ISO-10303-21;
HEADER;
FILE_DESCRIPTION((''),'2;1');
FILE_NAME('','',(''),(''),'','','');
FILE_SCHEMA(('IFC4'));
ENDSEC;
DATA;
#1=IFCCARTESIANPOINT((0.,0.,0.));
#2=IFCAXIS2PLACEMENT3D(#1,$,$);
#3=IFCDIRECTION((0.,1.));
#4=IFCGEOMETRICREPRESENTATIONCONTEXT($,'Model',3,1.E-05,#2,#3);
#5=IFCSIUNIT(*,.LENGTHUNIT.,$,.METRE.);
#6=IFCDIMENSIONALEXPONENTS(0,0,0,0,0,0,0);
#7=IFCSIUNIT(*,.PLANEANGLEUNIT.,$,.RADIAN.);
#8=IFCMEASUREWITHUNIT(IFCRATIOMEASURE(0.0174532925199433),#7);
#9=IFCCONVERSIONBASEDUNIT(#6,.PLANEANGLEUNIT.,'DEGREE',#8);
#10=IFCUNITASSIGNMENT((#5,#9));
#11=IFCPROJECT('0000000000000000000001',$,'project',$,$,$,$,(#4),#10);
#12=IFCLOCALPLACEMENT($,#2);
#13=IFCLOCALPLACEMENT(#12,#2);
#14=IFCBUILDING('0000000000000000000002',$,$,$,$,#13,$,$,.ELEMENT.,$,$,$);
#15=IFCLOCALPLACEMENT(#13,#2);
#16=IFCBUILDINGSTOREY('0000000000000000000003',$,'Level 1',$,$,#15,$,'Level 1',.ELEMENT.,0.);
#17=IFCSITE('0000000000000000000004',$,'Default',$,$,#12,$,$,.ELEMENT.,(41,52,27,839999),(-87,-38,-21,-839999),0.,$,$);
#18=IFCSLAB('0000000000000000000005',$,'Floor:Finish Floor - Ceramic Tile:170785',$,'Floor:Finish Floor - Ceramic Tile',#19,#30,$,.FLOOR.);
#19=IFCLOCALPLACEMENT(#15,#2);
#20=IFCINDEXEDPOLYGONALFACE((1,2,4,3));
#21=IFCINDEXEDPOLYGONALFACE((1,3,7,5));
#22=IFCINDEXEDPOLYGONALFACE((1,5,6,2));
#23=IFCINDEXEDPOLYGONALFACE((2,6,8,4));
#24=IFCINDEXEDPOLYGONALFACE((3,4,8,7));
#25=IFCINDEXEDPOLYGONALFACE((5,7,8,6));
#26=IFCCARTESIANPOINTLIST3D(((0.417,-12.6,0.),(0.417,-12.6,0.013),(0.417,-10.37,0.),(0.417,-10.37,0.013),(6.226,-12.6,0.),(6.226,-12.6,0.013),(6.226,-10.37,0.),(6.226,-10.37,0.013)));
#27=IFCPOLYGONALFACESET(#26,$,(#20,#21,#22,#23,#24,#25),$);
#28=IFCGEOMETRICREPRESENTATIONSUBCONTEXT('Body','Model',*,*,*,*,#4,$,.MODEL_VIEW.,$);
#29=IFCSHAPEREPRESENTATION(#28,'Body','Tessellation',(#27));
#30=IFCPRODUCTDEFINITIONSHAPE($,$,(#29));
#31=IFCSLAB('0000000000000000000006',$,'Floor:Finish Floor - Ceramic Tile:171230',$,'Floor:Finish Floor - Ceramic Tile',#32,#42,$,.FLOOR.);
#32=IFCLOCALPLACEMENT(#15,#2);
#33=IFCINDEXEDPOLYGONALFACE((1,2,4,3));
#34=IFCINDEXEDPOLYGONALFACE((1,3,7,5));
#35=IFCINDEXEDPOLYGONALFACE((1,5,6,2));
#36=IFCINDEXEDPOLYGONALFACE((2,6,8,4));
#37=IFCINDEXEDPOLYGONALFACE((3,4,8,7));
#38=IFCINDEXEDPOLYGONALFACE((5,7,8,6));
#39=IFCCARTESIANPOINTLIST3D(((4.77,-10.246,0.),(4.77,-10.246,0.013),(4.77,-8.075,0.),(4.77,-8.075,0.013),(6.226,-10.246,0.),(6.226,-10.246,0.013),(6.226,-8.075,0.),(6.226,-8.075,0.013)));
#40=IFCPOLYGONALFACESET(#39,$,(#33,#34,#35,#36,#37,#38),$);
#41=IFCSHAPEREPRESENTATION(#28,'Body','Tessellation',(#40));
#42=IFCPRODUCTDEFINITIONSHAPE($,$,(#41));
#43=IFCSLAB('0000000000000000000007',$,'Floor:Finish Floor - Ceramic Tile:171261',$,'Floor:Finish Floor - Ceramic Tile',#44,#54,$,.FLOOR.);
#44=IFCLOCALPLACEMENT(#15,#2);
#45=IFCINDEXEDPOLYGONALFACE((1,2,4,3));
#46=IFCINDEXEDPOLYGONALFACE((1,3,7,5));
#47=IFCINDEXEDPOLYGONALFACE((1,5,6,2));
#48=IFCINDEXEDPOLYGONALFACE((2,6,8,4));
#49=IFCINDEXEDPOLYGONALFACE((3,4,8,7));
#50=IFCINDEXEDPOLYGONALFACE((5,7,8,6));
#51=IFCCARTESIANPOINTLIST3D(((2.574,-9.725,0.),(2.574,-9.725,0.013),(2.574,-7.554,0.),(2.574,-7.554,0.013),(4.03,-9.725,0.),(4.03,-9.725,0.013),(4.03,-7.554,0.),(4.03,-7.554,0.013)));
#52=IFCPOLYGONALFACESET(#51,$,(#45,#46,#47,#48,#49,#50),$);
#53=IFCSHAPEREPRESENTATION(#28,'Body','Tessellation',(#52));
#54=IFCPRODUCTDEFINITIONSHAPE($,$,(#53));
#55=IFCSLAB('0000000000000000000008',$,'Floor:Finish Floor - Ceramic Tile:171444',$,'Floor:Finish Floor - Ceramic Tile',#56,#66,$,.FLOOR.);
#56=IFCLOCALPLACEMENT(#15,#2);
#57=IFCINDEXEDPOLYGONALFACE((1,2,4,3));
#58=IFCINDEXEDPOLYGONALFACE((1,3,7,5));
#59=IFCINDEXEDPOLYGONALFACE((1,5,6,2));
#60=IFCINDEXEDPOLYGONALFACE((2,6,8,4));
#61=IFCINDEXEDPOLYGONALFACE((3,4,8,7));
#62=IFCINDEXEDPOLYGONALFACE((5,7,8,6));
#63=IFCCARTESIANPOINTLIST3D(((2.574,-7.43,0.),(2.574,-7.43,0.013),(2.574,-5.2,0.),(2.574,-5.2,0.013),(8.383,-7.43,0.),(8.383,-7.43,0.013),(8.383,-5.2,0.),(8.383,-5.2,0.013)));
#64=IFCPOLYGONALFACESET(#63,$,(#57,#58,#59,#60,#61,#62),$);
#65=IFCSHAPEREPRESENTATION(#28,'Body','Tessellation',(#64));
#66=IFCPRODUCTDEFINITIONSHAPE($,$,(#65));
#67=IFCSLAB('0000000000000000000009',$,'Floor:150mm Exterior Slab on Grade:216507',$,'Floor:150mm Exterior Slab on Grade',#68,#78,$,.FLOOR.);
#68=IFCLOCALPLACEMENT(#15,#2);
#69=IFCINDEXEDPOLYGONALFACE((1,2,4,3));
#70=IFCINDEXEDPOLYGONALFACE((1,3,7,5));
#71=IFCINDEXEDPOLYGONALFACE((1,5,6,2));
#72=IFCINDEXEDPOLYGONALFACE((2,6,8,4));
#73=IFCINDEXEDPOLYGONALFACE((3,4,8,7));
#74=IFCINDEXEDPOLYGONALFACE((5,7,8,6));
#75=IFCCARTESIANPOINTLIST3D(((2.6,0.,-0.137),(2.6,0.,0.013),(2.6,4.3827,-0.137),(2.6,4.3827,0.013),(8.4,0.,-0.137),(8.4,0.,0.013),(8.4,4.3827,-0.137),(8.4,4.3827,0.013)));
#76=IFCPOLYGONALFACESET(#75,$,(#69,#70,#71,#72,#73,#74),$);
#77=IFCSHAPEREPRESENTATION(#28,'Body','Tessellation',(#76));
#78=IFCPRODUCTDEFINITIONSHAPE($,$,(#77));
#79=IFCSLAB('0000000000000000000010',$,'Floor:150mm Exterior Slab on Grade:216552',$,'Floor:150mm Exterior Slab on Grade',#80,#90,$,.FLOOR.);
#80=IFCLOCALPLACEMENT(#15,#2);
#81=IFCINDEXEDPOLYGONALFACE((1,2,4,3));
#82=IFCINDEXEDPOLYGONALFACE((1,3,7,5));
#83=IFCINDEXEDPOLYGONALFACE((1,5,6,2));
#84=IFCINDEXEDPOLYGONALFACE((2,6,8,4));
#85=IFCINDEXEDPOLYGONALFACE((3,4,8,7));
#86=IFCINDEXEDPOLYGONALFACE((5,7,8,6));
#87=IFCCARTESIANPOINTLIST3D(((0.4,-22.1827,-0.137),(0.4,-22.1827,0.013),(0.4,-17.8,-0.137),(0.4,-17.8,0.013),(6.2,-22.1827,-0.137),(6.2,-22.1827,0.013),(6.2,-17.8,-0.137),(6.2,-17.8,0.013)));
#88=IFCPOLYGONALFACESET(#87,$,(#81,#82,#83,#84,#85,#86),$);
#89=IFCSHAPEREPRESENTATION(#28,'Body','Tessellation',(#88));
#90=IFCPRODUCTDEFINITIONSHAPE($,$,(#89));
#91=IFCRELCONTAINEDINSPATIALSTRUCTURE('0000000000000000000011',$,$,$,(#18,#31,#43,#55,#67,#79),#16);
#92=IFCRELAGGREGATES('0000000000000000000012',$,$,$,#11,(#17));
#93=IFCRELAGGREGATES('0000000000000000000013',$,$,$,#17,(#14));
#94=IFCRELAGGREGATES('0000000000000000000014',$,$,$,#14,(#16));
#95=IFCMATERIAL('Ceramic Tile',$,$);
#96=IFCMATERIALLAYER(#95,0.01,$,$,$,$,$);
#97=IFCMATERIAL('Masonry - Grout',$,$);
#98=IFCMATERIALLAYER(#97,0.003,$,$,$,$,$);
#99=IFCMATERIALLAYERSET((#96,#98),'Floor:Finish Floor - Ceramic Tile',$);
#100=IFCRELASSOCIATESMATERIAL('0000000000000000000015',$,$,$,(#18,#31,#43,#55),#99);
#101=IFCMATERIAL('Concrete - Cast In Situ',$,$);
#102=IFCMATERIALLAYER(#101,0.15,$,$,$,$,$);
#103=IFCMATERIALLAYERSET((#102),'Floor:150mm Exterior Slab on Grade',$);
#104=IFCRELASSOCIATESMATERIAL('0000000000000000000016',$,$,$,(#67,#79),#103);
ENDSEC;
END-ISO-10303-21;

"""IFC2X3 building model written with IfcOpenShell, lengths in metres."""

from ifc_helpers import new_model, entity, si_unit, converted_unit, direction, frame, frame_2d, origin, place, context, subcontext, project, spatial, rectangle, extrude, material, layer, layer_set, layer_usage, element, save


model = new_model("IFC2X3")

# Units and contexts
model_context = context("Model", 3, precision=1e-05, world=origin(), true_north=direction((0.0, 1.0)))
body_context = subcontext(model_context, "Body", "Model", "MODEL_VIEW")
ifc_project = project(units=[si_unit("LENGTHUNIT", "METRE"), converted_unit("PLANEANGLEUNIT", "DEGREE", entity("IfcRatioMeasure", 0.0174532925199433), si_unit("PLANEANGLEUNIT", "RADIAN"), dimensions=[0, 0, 0, 0, 0, 0, 0])], contexts=[model_context])

# Site, building, storey
site_placement = place(None, origin())
site = spatial("IfcSite", under=ifc_project, at=site_placement, Name="Default", CompositionType="ELEMENT", RefLatitude=(41, 52, 27, 839999), RefLongitude=(-87, -38, -21, -839999), RefElevation=0.0)
building_placement = place(site_placement, origin())
building = spatial("IfcBuilding", under=site, at=building_placement, CompositionType="ELEMENT")
storey_placement = place(building_placement, origin())
storey = spatial("IfcBuildingStorey", under=building, at=storey_placement, Name="Level 1", LongName="Level 1", CompositionType="ELEMENT", Elevation=0.0)

# Slabs
ifc_material_1 = material(Name="Ceramic Tile")
ifc_layer_1 = layer(ifc_material_1, 0.01)
ifc_material_2 = material(Name="Masonry - Grout")
ifc_layer_2 = layer(ifc_material_2, 0.003)
ifc_layer_set_1 = layer_set([ifc_layer_1, ifc_layer_2], Name="Floor:Finish Floor - Ceramic Tile")
ifc_layer_usage_1 = layer_usage(ifc_layer_set_1, "AXIS3", "POSITIVE", 0.0)
slab_1_placement = place(storey_placement, origin())
element("IfcSlab", 1, at=slab_1_placement, inside=storey, material=ifc_layer_usage_1, Name="Floor:Finish Floor - Ceramic Tile:170785", ObjectType="Floor:Finish Floor - Ceramic Tile", PredefinedType="FLOOR", context=body_context, shape_type="SweptSolid", body=[
    extrude(rectangle(XDim=2.23, YDim=5.809, at=frame_2d((0.0, 0.0), x_axis=(1.0, 0.0))), frame((3.3215, -11.485, 0.013), z_axis=(0.0, 0.0, -1.0), x_axis=(0.0, 1.0, 0.0)), (0.0, 0.0, 1.0), 0.013),
])
ifc_layer_usage_2 = layer_usage(ifc_layer_set_1, "AXIS3", "POSITIVE", 0.0)
slab_2_placement = place(storey_placement, origin())
element("IfcSlab", 2, at=slab_2_placement, inside=storey, material=ifc_layer_usage_2, Name="Floor:Finish Floor - Ceramic Tile:171230", ObjectType="Floor:Finish Floor - Ceramic Tile", PredefinedType="FLOOR", context=body_context, shape_type="SweptSolid", body=[
    extrude(rectangle(XDim=2.171, YDim=1.456, at=frame_2d((0.0, 0.0), x_axis=(1.0, 0.0))), frame((5.498, -9.1605, 0.013), z_axis=(0.0, 0.0, -1.0), x_axis=(0.0, 1.0, 0.0)), (0.0, 0.0, 1.0), 0.013),
])
ifc_layer_usage_3 = layer_usage(ifc_layer_set_1, "AXIS3", "POSITIVE", 0.0)
slab_3_placement = place(storey_placement, origin())
element("IfcSlab", 3, at=slab_3_placement, inside=storey, material=ifc_layer_usage_3, Name="Floor:Finish Floor - Ceramic Tile:171261", ObjectType="Floor:Finish Floor - Ceramic Tile", PredefinedType="FLOOR", context=body_context, shape_type="SweptSolid", body=[
    extrude(rectangle(XDim=2.171, YDim=1.456, at=frame_2d((0.0, 0.0), x_axis=(1.0, 0.0))), frame((3.302, -8.6395, 0.013), z_axis=(0.0, 0.0, -1.0), x_axis=(0.0, 1.0, 0.0)), (0.0, 0.0, 1.0), 0.013),
])
ifc_layer_usage_4 = layer_usage(ifc_layer_set_1, "AXIS3", "POSITIVE", 0.0)
slab_4_placement = place(storey_placement, origin())
element("IfcSlab", 4, at=slab_4_placement, inside=storey, material=ifc_layer_usage_4, Name="Floor:Finish Floor - Ceramic Tile:171444", ObjectType="Floor:Finish Floor - Ceramic Tile", PredefinedType="FLOOR", context=body_context, shape_type="SweptSolid", body=[
    extrude(rectangle(XDim=2.23, YDim=5.809, at=frame_2d((0.0, 0.0), x_axis=(1.0, 0.0))), frame((5.4785, -6.315, 0.013), z_axis=(0.0, 0.0, -1.0), x_axis=(0.0, 1.0, 0.0)), (0.0, 0.0, 1.0), 0.013),
])
ifc_material_3 = material(Name="Concrete - Cast In Situ")
ifc_layer_3 = layer(ifc_material_3, 0.15)
ifc_layer_set_2 = layer_set([ifc_layer_3], Name="Floor:150mm Exterior Slab on Grade")
ifc_layer_usage_5 = layer_usage(ifc_layer_set_2, "AXIS3", "POSITIVE", 0.0)
slab_5_placement = place(storey_placement, origin())
element("IfcSlab", 5, at=slab_5_placement, inside=storey, material=ifc_layer_usage_5, Name="Floor:150mm Exterior Slab on Grade:216507", ObjectType="Floor:150mm Exterior Slab on Grade", PredefinedType="FLOOR", context=body_context, shape_type="SweptSolid", body=[
    extrude(rectangle(XDim=4.3827, YDim=5.8, at=frame_2d((0.0, 0.0), x_axis=(1.0, 0.0))), frame((5.5, 2.1914, 0.013), z_axis=(0.0, 0.0, -1.0), x_axis=(0.0, 1.0, 0.0)), (0.0, 0.0, 1.0), 0.15),
])
ifc_layer_usage_6 = layer_usage(ifc_layer_set_2, "AXIS3", "POSITIVE", 0.0)
slab_6_placement = place(storey_placement, origin())
element("IfcSlab", 6, at=slab_6_placement, inside=storey, material=ifc_layer_usage_6, Name="Floor:150mm Exterior Slab on Grade:216552", ObjectType="Floor:150mm Exterior Slab on Grade", PredefinedType="FLOOR", context=body_context, shape_type="SweptSolid", body=[
    extrude(rectangle(XDim=4.3827, YDim=5.8, at=frame_2d((0.0, 0.0), x_axis=(1.0, 0.0))), frame((3.3, -19.9914, 0.013), z_axis=(0.0, 0.0, -1.0), x_axis=(0.0, 1.0, 0.0)), (0.0, 0.0, 1.0), 0.15),
])

save(model, "model.ifc")
